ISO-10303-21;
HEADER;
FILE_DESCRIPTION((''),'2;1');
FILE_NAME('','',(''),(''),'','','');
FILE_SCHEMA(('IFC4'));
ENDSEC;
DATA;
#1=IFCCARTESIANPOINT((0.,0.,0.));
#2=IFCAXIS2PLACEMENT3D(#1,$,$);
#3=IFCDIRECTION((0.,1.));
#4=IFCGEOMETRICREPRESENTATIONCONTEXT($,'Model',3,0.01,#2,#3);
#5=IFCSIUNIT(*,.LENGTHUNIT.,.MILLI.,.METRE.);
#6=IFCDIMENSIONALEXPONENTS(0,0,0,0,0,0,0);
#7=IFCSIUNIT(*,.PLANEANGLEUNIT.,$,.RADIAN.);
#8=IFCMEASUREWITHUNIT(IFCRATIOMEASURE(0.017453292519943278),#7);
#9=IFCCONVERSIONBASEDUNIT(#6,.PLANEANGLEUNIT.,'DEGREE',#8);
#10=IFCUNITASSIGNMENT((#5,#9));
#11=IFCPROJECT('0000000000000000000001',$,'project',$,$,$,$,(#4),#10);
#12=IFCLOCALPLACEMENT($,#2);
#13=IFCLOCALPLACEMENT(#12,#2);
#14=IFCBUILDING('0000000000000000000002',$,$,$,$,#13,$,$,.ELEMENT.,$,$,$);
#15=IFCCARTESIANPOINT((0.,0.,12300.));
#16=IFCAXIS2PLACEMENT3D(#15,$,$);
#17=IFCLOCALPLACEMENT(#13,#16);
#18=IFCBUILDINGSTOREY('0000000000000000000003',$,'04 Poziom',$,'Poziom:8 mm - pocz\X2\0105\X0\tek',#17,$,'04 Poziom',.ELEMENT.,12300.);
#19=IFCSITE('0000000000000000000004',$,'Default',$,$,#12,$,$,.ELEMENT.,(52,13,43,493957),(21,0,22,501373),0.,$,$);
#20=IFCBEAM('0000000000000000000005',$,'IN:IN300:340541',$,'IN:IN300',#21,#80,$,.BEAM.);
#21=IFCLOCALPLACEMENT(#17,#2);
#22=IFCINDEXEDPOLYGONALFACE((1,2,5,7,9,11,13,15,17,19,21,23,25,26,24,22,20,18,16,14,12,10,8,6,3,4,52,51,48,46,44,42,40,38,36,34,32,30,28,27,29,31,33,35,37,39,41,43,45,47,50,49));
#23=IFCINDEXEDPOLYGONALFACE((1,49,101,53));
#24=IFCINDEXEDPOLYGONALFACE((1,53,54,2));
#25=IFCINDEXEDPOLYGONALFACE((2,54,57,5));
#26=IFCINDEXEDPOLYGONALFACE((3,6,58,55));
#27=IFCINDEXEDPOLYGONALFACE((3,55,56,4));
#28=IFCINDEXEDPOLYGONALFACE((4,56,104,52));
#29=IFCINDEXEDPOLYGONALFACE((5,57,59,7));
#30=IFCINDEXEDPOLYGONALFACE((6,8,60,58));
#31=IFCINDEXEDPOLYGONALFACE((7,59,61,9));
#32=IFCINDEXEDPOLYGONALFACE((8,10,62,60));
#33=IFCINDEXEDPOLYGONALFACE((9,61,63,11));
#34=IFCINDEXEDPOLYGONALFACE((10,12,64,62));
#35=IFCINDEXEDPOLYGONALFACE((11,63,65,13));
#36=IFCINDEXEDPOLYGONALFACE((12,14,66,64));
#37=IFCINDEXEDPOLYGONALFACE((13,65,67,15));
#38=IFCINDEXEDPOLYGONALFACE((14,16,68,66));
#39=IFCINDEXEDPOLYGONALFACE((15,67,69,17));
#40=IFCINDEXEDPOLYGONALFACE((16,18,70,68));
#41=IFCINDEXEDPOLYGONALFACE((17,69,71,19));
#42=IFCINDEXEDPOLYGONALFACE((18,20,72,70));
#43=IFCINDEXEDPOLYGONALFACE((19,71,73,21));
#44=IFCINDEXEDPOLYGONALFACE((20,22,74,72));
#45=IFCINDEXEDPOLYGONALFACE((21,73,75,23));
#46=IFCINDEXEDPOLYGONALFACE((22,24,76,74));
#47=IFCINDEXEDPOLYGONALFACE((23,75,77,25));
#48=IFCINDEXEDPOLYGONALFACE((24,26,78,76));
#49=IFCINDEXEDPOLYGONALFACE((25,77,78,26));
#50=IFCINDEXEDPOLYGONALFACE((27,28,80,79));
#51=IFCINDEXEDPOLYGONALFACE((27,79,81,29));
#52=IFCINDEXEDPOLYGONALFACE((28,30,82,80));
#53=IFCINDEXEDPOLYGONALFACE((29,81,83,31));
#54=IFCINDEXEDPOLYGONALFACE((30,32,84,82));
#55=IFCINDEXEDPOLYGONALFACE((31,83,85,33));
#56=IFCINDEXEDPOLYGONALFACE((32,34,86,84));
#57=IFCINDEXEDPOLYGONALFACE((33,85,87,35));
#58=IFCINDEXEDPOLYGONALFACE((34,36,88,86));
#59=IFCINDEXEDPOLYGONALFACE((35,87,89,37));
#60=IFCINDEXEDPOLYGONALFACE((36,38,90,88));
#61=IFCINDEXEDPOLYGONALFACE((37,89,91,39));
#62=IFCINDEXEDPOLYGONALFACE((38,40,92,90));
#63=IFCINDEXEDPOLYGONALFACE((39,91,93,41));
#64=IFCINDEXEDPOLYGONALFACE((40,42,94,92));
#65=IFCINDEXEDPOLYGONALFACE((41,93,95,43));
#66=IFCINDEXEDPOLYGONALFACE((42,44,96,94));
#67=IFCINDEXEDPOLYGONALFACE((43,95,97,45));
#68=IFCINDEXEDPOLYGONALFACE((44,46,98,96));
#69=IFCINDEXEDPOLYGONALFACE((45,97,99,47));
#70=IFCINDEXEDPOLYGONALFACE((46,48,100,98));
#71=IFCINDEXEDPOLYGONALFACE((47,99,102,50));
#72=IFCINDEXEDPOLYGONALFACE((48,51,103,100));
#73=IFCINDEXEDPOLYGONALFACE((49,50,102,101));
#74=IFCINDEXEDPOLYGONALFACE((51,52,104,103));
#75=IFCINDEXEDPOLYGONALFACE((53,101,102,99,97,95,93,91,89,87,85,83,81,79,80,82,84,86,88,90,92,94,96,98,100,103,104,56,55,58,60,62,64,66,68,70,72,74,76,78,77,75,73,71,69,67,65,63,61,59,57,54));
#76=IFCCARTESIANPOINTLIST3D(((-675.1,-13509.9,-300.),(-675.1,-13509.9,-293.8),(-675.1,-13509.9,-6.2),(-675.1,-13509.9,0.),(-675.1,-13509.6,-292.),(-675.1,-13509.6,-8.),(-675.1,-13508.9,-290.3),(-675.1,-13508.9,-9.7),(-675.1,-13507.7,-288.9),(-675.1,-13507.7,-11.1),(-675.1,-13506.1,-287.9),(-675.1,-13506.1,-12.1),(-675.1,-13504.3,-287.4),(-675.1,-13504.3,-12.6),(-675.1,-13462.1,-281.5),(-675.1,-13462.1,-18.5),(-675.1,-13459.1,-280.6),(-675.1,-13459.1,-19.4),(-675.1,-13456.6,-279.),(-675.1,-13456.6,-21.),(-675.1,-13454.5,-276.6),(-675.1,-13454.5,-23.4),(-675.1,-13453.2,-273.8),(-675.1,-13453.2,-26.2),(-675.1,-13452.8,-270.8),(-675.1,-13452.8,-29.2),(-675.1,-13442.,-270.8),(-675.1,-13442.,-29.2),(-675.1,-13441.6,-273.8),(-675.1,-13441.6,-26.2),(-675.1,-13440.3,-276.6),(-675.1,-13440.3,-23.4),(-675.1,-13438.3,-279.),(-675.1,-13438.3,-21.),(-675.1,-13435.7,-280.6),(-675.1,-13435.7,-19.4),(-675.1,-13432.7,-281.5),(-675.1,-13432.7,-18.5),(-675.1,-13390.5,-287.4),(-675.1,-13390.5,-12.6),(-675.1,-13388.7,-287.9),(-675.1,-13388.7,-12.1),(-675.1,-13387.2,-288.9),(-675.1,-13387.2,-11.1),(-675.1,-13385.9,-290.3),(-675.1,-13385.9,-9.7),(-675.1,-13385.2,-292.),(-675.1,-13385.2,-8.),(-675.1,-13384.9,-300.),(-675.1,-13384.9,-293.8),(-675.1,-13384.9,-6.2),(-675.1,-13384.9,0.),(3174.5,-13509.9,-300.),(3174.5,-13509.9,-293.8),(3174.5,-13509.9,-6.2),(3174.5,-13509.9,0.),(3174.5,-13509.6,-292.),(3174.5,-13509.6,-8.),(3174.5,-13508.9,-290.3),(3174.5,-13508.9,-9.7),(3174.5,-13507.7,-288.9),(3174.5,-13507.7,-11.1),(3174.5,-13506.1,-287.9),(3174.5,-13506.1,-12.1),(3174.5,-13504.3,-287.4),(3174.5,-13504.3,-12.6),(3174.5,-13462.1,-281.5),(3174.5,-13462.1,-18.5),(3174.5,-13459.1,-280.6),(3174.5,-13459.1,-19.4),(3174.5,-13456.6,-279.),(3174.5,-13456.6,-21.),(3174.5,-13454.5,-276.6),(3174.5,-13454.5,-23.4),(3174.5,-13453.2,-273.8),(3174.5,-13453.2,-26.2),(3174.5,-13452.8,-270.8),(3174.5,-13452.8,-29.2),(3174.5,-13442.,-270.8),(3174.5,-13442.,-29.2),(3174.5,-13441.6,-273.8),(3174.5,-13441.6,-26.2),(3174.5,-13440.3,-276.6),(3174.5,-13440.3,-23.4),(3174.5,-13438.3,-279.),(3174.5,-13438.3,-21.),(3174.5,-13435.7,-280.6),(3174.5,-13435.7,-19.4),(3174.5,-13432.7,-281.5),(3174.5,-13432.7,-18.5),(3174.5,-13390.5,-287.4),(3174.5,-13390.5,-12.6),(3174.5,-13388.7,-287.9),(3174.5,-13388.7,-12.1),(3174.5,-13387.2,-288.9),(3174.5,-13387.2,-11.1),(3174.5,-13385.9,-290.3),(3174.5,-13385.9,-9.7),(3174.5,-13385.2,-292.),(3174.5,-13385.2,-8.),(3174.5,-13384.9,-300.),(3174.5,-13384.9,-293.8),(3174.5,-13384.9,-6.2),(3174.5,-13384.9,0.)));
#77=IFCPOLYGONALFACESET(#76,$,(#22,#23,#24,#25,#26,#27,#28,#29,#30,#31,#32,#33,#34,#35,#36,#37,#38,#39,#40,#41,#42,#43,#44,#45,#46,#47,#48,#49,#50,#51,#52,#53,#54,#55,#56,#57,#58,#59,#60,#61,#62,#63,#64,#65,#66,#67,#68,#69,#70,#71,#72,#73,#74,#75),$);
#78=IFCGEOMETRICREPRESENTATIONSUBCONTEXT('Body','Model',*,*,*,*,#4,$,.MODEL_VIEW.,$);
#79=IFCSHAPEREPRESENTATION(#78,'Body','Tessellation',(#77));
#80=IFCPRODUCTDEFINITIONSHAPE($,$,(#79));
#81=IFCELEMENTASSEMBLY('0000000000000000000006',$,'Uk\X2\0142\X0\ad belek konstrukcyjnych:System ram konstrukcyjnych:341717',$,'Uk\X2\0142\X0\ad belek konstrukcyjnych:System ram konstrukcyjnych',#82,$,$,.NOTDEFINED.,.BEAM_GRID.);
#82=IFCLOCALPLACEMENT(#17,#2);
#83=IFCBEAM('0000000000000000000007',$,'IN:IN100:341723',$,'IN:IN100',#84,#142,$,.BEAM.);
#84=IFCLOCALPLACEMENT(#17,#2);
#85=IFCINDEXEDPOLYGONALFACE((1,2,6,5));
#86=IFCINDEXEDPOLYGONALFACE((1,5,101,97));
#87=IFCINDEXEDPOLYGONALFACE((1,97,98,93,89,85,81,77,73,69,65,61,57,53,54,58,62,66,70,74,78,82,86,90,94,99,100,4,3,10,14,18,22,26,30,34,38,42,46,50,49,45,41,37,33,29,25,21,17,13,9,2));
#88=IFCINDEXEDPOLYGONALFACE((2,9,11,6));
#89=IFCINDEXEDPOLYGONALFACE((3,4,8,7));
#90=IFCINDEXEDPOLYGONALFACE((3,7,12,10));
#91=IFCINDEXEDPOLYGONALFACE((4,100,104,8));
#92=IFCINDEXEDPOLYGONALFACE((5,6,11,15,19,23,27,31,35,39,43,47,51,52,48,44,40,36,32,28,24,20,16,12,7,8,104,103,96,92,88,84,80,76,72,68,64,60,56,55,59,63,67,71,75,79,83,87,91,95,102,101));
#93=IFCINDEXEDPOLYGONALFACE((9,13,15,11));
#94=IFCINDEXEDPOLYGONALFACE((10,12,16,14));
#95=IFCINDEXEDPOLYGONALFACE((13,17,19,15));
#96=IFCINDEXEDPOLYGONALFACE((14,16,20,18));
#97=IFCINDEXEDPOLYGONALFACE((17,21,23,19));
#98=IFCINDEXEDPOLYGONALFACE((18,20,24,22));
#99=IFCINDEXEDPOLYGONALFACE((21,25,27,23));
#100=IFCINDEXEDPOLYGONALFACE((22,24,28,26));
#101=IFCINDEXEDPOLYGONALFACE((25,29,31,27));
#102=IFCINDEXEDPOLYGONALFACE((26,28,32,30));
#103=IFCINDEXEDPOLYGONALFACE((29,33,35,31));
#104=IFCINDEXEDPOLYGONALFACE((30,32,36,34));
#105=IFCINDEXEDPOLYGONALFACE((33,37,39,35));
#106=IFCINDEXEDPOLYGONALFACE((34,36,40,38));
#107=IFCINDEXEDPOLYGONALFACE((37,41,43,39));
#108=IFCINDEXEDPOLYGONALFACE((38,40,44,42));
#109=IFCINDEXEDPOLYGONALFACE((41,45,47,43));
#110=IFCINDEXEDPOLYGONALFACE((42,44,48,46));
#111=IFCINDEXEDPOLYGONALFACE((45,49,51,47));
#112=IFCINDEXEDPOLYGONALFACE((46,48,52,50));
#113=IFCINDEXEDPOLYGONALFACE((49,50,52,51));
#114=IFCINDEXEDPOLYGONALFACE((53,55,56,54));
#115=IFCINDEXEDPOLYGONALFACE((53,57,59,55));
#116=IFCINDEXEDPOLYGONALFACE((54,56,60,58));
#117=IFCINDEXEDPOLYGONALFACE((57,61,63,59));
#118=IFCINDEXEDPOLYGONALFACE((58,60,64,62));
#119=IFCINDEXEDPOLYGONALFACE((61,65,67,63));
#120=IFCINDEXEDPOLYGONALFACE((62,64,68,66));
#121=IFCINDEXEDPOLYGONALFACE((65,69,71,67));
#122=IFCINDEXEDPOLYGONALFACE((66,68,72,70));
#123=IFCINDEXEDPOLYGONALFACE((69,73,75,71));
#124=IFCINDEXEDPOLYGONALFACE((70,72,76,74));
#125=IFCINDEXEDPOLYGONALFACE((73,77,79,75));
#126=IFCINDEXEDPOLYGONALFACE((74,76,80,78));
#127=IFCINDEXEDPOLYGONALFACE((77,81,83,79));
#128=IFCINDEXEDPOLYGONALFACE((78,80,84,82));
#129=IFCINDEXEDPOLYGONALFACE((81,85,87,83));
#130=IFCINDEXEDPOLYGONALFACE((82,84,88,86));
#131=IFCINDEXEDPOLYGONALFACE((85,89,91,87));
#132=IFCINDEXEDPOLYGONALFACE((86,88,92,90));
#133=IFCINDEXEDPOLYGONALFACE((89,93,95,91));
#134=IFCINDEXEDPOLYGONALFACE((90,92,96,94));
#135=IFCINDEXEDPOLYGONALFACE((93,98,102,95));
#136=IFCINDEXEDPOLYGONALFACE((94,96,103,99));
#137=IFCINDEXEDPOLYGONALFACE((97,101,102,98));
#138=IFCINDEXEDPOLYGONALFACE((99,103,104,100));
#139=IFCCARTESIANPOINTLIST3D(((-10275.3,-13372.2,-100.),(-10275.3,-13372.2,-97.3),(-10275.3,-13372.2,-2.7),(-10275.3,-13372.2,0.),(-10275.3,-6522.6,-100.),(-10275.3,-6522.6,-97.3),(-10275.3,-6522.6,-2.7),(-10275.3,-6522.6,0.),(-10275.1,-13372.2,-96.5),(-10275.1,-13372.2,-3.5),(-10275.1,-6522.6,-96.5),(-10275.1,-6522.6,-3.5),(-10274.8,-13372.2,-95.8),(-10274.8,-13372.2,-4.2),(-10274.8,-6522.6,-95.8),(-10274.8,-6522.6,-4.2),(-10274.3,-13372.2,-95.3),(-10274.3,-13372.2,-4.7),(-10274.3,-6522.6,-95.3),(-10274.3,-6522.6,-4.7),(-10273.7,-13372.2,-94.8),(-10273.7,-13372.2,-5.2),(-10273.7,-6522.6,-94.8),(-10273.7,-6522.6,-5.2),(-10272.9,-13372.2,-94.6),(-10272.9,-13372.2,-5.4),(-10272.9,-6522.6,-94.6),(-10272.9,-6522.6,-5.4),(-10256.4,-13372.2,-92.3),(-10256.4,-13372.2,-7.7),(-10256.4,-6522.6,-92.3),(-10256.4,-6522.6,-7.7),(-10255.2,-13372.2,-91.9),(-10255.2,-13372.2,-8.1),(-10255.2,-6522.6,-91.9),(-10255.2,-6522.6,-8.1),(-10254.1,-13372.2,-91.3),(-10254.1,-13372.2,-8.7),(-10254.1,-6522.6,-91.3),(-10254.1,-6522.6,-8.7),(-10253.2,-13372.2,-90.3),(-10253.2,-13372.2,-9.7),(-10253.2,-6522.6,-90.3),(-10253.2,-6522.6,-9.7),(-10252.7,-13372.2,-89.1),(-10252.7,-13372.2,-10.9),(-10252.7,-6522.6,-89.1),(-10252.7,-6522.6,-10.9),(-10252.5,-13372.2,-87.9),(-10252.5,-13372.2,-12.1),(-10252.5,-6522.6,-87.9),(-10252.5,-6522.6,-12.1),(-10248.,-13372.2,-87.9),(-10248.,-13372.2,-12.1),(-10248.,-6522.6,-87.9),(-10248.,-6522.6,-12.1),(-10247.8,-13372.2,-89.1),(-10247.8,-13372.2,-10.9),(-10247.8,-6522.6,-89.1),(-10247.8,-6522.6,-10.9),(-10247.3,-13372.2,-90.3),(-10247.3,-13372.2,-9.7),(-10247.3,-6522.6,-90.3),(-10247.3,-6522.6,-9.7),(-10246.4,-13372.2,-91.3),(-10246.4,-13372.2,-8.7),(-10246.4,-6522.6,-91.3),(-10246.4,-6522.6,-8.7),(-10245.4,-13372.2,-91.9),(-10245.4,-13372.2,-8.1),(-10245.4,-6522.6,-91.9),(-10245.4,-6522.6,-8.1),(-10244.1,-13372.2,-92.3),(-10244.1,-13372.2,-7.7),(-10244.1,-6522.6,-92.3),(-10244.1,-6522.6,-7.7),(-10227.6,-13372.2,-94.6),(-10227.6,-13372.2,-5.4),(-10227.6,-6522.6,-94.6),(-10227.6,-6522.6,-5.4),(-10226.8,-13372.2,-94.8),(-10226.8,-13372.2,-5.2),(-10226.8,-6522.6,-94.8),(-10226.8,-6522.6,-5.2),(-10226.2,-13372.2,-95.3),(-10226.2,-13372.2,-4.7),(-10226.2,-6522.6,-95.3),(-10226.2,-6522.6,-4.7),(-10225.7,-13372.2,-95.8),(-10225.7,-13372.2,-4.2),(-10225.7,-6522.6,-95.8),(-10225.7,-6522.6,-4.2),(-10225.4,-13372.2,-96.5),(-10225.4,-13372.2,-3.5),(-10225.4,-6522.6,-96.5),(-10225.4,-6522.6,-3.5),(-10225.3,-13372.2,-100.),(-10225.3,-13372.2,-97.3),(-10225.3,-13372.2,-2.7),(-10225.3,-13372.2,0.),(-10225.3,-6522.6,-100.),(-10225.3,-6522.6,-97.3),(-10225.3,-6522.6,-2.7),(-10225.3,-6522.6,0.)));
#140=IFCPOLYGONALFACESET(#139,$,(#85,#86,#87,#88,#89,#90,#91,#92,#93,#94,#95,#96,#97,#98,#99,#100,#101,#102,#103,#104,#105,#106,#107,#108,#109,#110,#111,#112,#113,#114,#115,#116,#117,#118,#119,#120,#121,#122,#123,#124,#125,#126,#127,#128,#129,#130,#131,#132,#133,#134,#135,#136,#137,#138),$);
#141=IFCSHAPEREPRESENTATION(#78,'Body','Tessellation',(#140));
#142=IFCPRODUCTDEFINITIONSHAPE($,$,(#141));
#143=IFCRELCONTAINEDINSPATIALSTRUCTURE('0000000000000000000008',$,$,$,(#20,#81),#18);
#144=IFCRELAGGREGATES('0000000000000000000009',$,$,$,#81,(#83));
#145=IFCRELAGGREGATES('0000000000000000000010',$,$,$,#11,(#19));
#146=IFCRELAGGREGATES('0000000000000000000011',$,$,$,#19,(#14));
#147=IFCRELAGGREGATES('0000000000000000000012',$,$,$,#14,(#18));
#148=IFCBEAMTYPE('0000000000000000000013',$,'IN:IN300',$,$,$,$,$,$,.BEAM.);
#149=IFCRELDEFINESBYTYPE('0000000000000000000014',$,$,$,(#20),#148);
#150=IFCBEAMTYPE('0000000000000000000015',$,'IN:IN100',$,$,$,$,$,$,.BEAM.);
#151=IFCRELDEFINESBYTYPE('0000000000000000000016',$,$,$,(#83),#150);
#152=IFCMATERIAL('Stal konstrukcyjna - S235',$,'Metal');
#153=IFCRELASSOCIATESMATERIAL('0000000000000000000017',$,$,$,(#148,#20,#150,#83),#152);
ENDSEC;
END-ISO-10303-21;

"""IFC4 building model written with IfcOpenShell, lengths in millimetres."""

from ifc_helpers import new_model, entity, si_unit, converted_unit, direction, frame, origin, place, context, subcontext, project, spatial, line, arc, indexed_curve, outline, extrude, source, transform, mapped, material, type_object, type_shapes, element, aggregate, save


model = new_model("IFC4")

# Units and contexts
model_context = context("Model", 3, precision=0.01, world=origin(), true_north=direction((0.0, 1.0)))
body_context = subcontext(model_context, "Body", "Model", "MODEL_VIEW")
ifc_project = project(units=[si_unit("LENGTHUNIT", "METRE", prefix="MILLI"), converted_unit("PLANEANGLEUNIT", "DEGREE", entity("IfcRatioMeasure", 0.017453292519943278), si_unit("PLANEANGLEUNIT", "RADIAN"), dimensions=[0, 0, 0, 0, 0, 0, 0])], contexts=[model_context])

# Site, building, storey
site_placement = place(None, origin())
site = spatial("IfcSite", under=ifc_project, at=site_placement, Name="Default", CompositionType="ELEMENT", RefLatitude=(52, 13, 43, 493957), RefLongitude=(21, 0, 22, 501373), RefElevation=0.0)
building_placement = place(site_placement, origin())
building = spatial("IfcBuilding", under=site, at=building_placement, CompositionType="ELEMENT")
storey_placement = place(building_placement, frame((0.0, 0.0, 12300.0)))
storey = spatial("IfcBuildingStorey", under=building, at=storey_placement, Name="04 Poziom", ObjectType="Poziom:8 mm - początek", LongName="04 Poziom", CompositionType="ELEMENT", Elevation=12300.0)

# Shared definitions
ifc_material = material(Name="Stal konstrukcyjna - S235", Category="Metal")

# Beam
beam_type_1 = type_object("IfcBeamType", Name="IN:IN300", PredefinedType="BEAM", material=ifc_material)
shared_shape_1 = source(origin(), body_context, "Body", "SweptSolid", [
    extrude(outline(indexed_curve([(143.8, -62.5), (150.0, -62.5), (150.0, 62.5), (143.8, 62.5), (139.6, 60.9), (137.4, 56.9), (131.5, 14.7), (127.9, 8.1), (120.8, 5.4), (-120.8, 5.4), (-127.9, 8.1), (-131.5, 14.7), (-137.4, 56.9), (-139.6, 60.9), (-143.8, 62.5), (-150.0, 62.5), (-150.0, -62.5), (-143.8, -62.5), (-139.6, -60.9), (-137.4, -56.9), (-131.5, -14.7), (-127.9, -8.1), (-120.8, -5.4), (120.8, -5.4), (127.9, -8.1), (131.5, -14.7), (137.4, -56.9), (139.6, -60.9)], segments=[line(1, 2, 3, 4), arc(4, 5, 6), line(6, 7), arc(7, 8, 9), line(9, 10), arc(10, 11, 12), line(12, 13), arc(13, 14, 15), line(15, 16, 17, 18), arc(18, 19, 20), line(20, 21), arc(21, 22, 23), line(23, 24), arc(24, 25, 26), line(26, 27), arc(27, 28, 1)], self_intersect=False)), frame((-1924.8, 0.0, 0.0), z_axis=(1.0, 0.0, 0.0), x_axis=(0.0, 0.0, -1.0)), (0.0, 0.0, 1.0), 3849.6),
])
type_shapes(beam_type_1, [shared_shape_1])
for number, where, name in (
    (1, (1249.7, -13447.4, -150.0), "IN:IN300:340541"),
):
    element("IfcBeam", number, at=place(storey_placement, frame(where)), inside=storey, type_object=beam_type_1, material=ifc_material, Name=name, ObjectType="IN:IN300", PredefinedType="BEAM", context=body_context, shape_type="MappedRepresentation", body=[
        mapped(shared_shape_1, transform((0.0, 0.0, 0.0), scale=1.0)),
    ])

# Element assembly, beam
assembly_1_placement = place(storey_placement, origin())
assembly_1 = element("IfcElementAssembly", 2, at=assembly_1_placement, inside=storey, Name="Układ belek konstrukcyjnych:System ram konstrukcyjnych:341717", ObjectType="Układ belek konstrukcyjnych:System ram konstrukcyjnych", AssemblyPlace="NOTDEFINED", PredefinedType="BEAM_GRID")
beam_type_2 = type_object("IfcBeamType", Name="IN:IN100", PredefinedType="BEAM", material=ifc_material)
shared_shape_2 = source(origin(), body_context, "Body", "SweptSolid", [
    extrude(outline(indexed_curve([(47.3, -25.0), (50.0, -25.0), (50.0, 25.0), (47.3, 25.0), (45.5, 24.3), (44.6, 22.7), (42.3, 6.1), (40.8, 3.4), (37.9, 2.2), (-37.9, 2.2), (-40.8, 3.4), (-42.3, 6.1), (-44.6, 22.7), (-45.5, 24.3), (-47.3, 25.0), (-50.0, 25.0), (-50.0, -25.0), (-47.3, -25.0), (-45.5, -24.3), (-44.6, -22.7), (-42.3, -6.1), (-40.8, -3.4), (-37.9, -2.2), (37.9, -2.2), (40.8, -3.4), (42.3, -6.1), (44.6, -22.7), (45.5, -24.3)], segments=[line(1, 2, 3, 4), arc(4, 5, 6), line(6, 7), arc(7, 8, 9), line(9, 10), arc(10, 11, 12), line(12, 13), arc(13, 14, 15), line(15, 16, 17, 18), arc(18, 19, 20), line(20, 21), arc(21, 22, 23), line(23, 24), arc(24, 25, 26), line(26, 27), arc(27, 28, 1)], self_intersect=False)), frame((-3424.8, 0.0, 0.0), z_axis=(1.0, 0.0, 0.0), x_axis=(0.0, 0.0, -1.0)), (0.0, 0.0, 1.0), 6849.6),
])
type_shapes(beam_type_2, [shared_shape_2])
beam_1_placement = place(assembly_1_placement, frame((-10250.3, -9947.4, -50.0), z_axis=(0.0, 0.0, 1.0), x_axis=(0.0, 1.0, 0.0)))
beam_1 = element("IfcBeam", 3, at=beam_1_placement, type_object=beam_type_2, material=ifc_material, Name="IN:IN100:341723", ObjectType="IN:IN100", PredefinedType="BEAM", context=body_context, shape_type="MappedRepresentation", body=[
    mapped(shared_shape_2, transform((0.0, 0.0, 0.0), scale=1.0)),
])
aggregate(assembly_1, [beam_1])

save(model, "model.ifc")
